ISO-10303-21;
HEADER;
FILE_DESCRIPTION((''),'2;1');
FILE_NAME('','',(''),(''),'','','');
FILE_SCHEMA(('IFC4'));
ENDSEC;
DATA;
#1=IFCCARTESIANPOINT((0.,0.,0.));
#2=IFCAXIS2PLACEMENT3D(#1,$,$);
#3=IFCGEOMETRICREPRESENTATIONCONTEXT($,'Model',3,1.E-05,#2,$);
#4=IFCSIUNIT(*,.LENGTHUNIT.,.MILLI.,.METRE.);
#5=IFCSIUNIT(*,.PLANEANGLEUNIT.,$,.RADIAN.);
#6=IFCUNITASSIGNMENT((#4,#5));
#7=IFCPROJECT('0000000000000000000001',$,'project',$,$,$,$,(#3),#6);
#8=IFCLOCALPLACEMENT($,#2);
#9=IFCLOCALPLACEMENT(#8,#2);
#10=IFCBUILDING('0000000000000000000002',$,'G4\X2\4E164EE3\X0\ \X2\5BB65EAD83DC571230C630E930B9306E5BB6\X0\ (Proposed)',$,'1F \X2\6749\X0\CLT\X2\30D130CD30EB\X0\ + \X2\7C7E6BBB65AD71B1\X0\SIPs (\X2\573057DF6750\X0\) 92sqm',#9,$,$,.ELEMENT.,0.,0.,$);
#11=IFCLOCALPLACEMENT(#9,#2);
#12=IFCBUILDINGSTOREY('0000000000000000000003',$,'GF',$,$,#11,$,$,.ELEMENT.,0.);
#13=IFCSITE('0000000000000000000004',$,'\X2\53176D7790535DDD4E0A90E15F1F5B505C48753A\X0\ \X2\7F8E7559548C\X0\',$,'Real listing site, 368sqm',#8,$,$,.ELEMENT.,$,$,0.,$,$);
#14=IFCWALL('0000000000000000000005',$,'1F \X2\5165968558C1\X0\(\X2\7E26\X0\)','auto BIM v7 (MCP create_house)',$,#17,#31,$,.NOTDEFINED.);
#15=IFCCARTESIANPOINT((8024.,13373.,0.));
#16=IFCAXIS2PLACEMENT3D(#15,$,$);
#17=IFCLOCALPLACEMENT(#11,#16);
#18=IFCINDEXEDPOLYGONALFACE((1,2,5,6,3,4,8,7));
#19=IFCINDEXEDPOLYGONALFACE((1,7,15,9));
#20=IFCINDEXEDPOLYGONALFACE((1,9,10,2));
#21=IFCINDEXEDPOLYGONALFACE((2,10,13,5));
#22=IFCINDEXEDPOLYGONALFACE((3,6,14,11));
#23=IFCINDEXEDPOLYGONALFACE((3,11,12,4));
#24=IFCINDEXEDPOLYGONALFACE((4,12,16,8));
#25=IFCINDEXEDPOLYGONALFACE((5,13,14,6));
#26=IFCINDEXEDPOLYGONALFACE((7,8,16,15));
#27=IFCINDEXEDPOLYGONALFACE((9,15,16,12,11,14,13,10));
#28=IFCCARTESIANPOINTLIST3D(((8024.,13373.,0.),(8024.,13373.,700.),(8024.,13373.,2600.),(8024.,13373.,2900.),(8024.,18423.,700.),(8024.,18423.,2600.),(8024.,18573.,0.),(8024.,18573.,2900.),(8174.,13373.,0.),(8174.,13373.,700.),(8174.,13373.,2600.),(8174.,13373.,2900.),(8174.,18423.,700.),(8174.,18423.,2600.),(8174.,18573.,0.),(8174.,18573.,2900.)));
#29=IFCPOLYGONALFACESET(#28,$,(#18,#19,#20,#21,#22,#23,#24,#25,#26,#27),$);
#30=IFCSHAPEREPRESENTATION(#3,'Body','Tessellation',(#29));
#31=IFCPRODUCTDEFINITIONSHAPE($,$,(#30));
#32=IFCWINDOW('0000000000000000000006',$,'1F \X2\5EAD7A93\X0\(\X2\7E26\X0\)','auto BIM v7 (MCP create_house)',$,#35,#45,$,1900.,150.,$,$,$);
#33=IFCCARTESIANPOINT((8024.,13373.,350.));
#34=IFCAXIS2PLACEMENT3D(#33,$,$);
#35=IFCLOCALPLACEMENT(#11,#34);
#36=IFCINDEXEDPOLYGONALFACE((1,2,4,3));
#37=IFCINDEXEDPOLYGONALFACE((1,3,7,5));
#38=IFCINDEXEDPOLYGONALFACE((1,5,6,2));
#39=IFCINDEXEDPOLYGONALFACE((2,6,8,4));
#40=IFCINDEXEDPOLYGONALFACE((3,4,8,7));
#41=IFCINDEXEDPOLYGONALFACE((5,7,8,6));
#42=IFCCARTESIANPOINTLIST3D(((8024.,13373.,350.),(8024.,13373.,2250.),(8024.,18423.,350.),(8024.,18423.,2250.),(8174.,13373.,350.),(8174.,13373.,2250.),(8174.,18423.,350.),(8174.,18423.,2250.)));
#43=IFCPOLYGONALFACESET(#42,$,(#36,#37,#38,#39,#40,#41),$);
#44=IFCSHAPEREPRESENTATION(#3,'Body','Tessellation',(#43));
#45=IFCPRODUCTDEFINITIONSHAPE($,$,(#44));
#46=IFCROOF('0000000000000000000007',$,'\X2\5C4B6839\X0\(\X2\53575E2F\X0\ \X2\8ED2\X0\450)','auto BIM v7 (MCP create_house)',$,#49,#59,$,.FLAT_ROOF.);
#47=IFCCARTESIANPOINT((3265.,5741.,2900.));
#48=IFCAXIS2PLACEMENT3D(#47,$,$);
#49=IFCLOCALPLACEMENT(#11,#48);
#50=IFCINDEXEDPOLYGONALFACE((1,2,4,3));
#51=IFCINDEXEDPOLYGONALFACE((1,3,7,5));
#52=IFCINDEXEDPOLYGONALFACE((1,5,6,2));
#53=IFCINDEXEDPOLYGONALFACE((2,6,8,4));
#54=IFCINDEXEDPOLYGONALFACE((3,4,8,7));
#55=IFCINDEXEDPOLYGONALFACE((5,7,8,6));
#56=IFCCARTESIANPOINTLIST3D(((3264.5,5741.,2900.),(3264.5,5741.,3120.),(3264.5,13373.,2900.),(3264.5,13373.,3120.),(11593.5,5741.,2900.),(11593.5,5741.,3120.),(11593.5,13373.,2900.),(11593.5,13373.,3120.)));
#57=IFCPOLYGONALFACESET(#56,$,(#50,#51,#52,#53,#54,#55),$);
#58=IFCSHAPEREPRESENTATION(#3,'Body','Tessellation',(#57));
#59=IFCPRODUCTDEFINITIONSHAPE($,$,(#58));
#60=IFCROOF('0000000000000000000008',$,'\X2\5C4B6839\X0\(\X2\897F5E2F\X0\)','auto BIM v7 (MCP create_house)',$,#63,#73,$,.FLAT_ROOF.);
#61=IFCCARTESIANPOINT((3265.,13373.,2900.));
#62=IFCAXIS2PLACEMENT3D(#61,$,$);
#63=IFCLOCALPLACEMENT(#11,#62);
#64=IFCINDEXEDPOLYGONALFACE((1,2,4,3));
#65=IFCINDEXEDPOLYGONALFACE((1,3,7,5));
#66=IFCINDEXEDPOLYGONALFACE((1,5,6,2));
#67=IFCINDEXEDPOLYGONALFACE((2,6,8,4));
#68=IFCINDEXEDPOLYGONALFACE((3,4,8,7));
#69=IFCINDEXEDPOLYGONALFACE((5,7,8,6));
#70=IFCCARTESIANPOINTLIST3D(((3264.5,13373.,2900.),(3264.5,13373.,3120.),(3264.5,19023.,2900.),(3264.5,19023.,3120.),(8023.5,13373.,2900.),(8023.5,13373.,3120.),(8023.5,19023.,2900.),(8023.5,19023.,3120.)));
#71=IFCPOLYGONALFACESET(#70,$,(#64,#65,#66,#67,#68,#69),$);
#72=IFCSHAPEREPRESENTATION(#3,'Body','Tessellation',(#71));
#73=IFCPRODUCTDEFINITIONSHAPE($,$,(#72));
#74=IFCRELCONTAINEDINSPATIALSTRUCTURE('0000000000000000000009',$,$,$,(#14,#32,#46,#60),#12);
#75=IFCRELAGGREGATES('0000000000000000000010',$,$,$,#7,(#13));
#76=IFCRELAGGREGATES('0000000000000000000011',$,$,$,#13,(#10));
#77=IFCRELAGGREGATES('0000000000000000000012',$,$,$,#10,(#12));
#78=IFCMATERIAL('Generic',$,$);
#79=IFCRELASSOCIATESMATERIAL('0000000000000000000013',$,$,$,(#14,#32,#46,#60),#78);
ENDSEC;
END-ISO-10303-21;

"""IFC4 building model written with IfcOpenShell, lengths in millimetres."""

from ifc_helpers import new_model, si_unit, frame, frame_2d, origin, place, context, project, spatial, rectangle, extrude, material, element, fill, save


model = new_model("IFC4")

# Units and contexts
model_context = context("Model", 3, precision=1e-05, world=origin())
ifc_project = project(units=[si_unit("LENGTHUNIT", "METRE", prefix="MILLI"), si_unit("PLANEANGLEUNIT", "RADIAN")], contexts=[model_context])

# Site, building, storey
site_placement = place(None, origin())
site = spatial("IfcSite", under=ifc_project, at=site_placement, Name="北海道川上郡弟子屈町 美留和", ObjectType="Real listing site, 368sqm", CompositionType="ELEMENT", RefElevation=0.0)
building_placement = place(site_placement, origin())
building = spatial("IfcBuilding", under=site, at=building_placement, Name="G4世代 家庭菜園テラスの家 (Proposed)", ObjectType="1F 杉CLTパネル + 籾殻断熱SIPs (地域材) 92sqm", CompositionType="ELEMENT", ElevationOfRefHeight=0.0, ElevationOfTerrain=0.0)
storey_placement = place(building_placement, origin())
storey = spatial("IfcBuildingStorey", under=building, at=storey_placement, Name="GF", CompositionType="ELEMENT", Elevation=0.0)

# Shared definitions
ifc_material = material(Name="Generic")

# Wall, opening, window
wall_1_placement = place(storey_placement, frame((8024.0, 13373.0, 0.0)))
wall_1 = element("IfcWall", 1, at=wall_1_placement, inside=storey, material=ifc_material, Name="1F 入隅壁(縦)", Description="auto BIM v7 (MCP create_house)", PredefinedType="NOTDEFINED", context=model_context, shape_type="SweptSolid", body=[
    extrude(rectangle(XDim=150.0, YDim=5200.0, at=frame_2d((75.0, 2600.0))), frame((8024.0, 13373.0, 0.0)), (0.0, 0.0, 1.0), 2900.0),
])
opening_1_placement = place(storey_placement, frame((8024.0, 13373.0, 350.0)))
opening_1 = element("IfcOpeningElement", 2, at=opening_1_placement, cuts=wall_1, PredefinedType="NOTDEFINED", context=model_context, shape_type="SweptSolid", body=[
    extrude(rectangle(XDim=150.0, YDim=5050.0, at=frame_2d((75.0, 2525.0))), frame((8024.0, 13373.0, 350.0)), (0.0, 0.0, 1.0), 1900.0),
])
window_1_placement = place(storey_placement, frame((8024.0, 13373.0, 350.0)))
window_1 = element("IfcWindow", 3, at=window_1_placement, inside=storey, material=ifc_material, Name="1F 庭窓(縦)", Description="auto BIM v7 (MCP create_house)", OverallHeight=1900.0, OverallWidth=150.0, context=model_context, shape_type="SweptSolid", body=[
    extrude(rectangle(XDim=150.0, YDim=5050.0, at=frame_2d((75.0, 2525.0))), frame((8024.0, 13373.0, 350.0)), (0.0, 0.0, 1.0), 1900.0),
])
fill(opening_1, window_1)

# Roofs
roof_1_placement = place(storey_placement, frame((3265.0, 5741.0, 2900.0)))
element("IfcRoof", 4, at=roof_1_placement, inside=storey, material=ifc_material, Name="屋根(南帯 軒450)", Description="auto BIM v7 (MCP create_house)", PredefinedType="FLAT_ROOF", context=model_context, shape_type="SweptSolid", body=[
    extrude(rectangle(XDim=8329.0, YDim=7632.0, at=frame_2d((4164.0, 3816.0))), frame((3265.0, 5741.0, 2900.0)), (0.0, 0.0, 1.0), 220.0),
])
roof_2_placement = place(storey_placement, frame((3265.0, 13373.0, 2900.0)))
element("IfcRoof", 5, at=roof_2_placement, inside=storey, material=ifc_material, Name="屋根(西帯)", Description="auto BIM v7 (MCP create_house)", PredefinedType="FLAT_ROOF", context=model_context, shape_type="SweptSolid", body=[
    extrude(rectangle(XDim=4759.0, YDim=5650.0, at=frame_2d((2379.0, 2825.0))), frame((3265.0, 13373.0, 2900.0)), (0.0, 0.0, 1.0), 220.0),
])

save(model, "model.ifc")
